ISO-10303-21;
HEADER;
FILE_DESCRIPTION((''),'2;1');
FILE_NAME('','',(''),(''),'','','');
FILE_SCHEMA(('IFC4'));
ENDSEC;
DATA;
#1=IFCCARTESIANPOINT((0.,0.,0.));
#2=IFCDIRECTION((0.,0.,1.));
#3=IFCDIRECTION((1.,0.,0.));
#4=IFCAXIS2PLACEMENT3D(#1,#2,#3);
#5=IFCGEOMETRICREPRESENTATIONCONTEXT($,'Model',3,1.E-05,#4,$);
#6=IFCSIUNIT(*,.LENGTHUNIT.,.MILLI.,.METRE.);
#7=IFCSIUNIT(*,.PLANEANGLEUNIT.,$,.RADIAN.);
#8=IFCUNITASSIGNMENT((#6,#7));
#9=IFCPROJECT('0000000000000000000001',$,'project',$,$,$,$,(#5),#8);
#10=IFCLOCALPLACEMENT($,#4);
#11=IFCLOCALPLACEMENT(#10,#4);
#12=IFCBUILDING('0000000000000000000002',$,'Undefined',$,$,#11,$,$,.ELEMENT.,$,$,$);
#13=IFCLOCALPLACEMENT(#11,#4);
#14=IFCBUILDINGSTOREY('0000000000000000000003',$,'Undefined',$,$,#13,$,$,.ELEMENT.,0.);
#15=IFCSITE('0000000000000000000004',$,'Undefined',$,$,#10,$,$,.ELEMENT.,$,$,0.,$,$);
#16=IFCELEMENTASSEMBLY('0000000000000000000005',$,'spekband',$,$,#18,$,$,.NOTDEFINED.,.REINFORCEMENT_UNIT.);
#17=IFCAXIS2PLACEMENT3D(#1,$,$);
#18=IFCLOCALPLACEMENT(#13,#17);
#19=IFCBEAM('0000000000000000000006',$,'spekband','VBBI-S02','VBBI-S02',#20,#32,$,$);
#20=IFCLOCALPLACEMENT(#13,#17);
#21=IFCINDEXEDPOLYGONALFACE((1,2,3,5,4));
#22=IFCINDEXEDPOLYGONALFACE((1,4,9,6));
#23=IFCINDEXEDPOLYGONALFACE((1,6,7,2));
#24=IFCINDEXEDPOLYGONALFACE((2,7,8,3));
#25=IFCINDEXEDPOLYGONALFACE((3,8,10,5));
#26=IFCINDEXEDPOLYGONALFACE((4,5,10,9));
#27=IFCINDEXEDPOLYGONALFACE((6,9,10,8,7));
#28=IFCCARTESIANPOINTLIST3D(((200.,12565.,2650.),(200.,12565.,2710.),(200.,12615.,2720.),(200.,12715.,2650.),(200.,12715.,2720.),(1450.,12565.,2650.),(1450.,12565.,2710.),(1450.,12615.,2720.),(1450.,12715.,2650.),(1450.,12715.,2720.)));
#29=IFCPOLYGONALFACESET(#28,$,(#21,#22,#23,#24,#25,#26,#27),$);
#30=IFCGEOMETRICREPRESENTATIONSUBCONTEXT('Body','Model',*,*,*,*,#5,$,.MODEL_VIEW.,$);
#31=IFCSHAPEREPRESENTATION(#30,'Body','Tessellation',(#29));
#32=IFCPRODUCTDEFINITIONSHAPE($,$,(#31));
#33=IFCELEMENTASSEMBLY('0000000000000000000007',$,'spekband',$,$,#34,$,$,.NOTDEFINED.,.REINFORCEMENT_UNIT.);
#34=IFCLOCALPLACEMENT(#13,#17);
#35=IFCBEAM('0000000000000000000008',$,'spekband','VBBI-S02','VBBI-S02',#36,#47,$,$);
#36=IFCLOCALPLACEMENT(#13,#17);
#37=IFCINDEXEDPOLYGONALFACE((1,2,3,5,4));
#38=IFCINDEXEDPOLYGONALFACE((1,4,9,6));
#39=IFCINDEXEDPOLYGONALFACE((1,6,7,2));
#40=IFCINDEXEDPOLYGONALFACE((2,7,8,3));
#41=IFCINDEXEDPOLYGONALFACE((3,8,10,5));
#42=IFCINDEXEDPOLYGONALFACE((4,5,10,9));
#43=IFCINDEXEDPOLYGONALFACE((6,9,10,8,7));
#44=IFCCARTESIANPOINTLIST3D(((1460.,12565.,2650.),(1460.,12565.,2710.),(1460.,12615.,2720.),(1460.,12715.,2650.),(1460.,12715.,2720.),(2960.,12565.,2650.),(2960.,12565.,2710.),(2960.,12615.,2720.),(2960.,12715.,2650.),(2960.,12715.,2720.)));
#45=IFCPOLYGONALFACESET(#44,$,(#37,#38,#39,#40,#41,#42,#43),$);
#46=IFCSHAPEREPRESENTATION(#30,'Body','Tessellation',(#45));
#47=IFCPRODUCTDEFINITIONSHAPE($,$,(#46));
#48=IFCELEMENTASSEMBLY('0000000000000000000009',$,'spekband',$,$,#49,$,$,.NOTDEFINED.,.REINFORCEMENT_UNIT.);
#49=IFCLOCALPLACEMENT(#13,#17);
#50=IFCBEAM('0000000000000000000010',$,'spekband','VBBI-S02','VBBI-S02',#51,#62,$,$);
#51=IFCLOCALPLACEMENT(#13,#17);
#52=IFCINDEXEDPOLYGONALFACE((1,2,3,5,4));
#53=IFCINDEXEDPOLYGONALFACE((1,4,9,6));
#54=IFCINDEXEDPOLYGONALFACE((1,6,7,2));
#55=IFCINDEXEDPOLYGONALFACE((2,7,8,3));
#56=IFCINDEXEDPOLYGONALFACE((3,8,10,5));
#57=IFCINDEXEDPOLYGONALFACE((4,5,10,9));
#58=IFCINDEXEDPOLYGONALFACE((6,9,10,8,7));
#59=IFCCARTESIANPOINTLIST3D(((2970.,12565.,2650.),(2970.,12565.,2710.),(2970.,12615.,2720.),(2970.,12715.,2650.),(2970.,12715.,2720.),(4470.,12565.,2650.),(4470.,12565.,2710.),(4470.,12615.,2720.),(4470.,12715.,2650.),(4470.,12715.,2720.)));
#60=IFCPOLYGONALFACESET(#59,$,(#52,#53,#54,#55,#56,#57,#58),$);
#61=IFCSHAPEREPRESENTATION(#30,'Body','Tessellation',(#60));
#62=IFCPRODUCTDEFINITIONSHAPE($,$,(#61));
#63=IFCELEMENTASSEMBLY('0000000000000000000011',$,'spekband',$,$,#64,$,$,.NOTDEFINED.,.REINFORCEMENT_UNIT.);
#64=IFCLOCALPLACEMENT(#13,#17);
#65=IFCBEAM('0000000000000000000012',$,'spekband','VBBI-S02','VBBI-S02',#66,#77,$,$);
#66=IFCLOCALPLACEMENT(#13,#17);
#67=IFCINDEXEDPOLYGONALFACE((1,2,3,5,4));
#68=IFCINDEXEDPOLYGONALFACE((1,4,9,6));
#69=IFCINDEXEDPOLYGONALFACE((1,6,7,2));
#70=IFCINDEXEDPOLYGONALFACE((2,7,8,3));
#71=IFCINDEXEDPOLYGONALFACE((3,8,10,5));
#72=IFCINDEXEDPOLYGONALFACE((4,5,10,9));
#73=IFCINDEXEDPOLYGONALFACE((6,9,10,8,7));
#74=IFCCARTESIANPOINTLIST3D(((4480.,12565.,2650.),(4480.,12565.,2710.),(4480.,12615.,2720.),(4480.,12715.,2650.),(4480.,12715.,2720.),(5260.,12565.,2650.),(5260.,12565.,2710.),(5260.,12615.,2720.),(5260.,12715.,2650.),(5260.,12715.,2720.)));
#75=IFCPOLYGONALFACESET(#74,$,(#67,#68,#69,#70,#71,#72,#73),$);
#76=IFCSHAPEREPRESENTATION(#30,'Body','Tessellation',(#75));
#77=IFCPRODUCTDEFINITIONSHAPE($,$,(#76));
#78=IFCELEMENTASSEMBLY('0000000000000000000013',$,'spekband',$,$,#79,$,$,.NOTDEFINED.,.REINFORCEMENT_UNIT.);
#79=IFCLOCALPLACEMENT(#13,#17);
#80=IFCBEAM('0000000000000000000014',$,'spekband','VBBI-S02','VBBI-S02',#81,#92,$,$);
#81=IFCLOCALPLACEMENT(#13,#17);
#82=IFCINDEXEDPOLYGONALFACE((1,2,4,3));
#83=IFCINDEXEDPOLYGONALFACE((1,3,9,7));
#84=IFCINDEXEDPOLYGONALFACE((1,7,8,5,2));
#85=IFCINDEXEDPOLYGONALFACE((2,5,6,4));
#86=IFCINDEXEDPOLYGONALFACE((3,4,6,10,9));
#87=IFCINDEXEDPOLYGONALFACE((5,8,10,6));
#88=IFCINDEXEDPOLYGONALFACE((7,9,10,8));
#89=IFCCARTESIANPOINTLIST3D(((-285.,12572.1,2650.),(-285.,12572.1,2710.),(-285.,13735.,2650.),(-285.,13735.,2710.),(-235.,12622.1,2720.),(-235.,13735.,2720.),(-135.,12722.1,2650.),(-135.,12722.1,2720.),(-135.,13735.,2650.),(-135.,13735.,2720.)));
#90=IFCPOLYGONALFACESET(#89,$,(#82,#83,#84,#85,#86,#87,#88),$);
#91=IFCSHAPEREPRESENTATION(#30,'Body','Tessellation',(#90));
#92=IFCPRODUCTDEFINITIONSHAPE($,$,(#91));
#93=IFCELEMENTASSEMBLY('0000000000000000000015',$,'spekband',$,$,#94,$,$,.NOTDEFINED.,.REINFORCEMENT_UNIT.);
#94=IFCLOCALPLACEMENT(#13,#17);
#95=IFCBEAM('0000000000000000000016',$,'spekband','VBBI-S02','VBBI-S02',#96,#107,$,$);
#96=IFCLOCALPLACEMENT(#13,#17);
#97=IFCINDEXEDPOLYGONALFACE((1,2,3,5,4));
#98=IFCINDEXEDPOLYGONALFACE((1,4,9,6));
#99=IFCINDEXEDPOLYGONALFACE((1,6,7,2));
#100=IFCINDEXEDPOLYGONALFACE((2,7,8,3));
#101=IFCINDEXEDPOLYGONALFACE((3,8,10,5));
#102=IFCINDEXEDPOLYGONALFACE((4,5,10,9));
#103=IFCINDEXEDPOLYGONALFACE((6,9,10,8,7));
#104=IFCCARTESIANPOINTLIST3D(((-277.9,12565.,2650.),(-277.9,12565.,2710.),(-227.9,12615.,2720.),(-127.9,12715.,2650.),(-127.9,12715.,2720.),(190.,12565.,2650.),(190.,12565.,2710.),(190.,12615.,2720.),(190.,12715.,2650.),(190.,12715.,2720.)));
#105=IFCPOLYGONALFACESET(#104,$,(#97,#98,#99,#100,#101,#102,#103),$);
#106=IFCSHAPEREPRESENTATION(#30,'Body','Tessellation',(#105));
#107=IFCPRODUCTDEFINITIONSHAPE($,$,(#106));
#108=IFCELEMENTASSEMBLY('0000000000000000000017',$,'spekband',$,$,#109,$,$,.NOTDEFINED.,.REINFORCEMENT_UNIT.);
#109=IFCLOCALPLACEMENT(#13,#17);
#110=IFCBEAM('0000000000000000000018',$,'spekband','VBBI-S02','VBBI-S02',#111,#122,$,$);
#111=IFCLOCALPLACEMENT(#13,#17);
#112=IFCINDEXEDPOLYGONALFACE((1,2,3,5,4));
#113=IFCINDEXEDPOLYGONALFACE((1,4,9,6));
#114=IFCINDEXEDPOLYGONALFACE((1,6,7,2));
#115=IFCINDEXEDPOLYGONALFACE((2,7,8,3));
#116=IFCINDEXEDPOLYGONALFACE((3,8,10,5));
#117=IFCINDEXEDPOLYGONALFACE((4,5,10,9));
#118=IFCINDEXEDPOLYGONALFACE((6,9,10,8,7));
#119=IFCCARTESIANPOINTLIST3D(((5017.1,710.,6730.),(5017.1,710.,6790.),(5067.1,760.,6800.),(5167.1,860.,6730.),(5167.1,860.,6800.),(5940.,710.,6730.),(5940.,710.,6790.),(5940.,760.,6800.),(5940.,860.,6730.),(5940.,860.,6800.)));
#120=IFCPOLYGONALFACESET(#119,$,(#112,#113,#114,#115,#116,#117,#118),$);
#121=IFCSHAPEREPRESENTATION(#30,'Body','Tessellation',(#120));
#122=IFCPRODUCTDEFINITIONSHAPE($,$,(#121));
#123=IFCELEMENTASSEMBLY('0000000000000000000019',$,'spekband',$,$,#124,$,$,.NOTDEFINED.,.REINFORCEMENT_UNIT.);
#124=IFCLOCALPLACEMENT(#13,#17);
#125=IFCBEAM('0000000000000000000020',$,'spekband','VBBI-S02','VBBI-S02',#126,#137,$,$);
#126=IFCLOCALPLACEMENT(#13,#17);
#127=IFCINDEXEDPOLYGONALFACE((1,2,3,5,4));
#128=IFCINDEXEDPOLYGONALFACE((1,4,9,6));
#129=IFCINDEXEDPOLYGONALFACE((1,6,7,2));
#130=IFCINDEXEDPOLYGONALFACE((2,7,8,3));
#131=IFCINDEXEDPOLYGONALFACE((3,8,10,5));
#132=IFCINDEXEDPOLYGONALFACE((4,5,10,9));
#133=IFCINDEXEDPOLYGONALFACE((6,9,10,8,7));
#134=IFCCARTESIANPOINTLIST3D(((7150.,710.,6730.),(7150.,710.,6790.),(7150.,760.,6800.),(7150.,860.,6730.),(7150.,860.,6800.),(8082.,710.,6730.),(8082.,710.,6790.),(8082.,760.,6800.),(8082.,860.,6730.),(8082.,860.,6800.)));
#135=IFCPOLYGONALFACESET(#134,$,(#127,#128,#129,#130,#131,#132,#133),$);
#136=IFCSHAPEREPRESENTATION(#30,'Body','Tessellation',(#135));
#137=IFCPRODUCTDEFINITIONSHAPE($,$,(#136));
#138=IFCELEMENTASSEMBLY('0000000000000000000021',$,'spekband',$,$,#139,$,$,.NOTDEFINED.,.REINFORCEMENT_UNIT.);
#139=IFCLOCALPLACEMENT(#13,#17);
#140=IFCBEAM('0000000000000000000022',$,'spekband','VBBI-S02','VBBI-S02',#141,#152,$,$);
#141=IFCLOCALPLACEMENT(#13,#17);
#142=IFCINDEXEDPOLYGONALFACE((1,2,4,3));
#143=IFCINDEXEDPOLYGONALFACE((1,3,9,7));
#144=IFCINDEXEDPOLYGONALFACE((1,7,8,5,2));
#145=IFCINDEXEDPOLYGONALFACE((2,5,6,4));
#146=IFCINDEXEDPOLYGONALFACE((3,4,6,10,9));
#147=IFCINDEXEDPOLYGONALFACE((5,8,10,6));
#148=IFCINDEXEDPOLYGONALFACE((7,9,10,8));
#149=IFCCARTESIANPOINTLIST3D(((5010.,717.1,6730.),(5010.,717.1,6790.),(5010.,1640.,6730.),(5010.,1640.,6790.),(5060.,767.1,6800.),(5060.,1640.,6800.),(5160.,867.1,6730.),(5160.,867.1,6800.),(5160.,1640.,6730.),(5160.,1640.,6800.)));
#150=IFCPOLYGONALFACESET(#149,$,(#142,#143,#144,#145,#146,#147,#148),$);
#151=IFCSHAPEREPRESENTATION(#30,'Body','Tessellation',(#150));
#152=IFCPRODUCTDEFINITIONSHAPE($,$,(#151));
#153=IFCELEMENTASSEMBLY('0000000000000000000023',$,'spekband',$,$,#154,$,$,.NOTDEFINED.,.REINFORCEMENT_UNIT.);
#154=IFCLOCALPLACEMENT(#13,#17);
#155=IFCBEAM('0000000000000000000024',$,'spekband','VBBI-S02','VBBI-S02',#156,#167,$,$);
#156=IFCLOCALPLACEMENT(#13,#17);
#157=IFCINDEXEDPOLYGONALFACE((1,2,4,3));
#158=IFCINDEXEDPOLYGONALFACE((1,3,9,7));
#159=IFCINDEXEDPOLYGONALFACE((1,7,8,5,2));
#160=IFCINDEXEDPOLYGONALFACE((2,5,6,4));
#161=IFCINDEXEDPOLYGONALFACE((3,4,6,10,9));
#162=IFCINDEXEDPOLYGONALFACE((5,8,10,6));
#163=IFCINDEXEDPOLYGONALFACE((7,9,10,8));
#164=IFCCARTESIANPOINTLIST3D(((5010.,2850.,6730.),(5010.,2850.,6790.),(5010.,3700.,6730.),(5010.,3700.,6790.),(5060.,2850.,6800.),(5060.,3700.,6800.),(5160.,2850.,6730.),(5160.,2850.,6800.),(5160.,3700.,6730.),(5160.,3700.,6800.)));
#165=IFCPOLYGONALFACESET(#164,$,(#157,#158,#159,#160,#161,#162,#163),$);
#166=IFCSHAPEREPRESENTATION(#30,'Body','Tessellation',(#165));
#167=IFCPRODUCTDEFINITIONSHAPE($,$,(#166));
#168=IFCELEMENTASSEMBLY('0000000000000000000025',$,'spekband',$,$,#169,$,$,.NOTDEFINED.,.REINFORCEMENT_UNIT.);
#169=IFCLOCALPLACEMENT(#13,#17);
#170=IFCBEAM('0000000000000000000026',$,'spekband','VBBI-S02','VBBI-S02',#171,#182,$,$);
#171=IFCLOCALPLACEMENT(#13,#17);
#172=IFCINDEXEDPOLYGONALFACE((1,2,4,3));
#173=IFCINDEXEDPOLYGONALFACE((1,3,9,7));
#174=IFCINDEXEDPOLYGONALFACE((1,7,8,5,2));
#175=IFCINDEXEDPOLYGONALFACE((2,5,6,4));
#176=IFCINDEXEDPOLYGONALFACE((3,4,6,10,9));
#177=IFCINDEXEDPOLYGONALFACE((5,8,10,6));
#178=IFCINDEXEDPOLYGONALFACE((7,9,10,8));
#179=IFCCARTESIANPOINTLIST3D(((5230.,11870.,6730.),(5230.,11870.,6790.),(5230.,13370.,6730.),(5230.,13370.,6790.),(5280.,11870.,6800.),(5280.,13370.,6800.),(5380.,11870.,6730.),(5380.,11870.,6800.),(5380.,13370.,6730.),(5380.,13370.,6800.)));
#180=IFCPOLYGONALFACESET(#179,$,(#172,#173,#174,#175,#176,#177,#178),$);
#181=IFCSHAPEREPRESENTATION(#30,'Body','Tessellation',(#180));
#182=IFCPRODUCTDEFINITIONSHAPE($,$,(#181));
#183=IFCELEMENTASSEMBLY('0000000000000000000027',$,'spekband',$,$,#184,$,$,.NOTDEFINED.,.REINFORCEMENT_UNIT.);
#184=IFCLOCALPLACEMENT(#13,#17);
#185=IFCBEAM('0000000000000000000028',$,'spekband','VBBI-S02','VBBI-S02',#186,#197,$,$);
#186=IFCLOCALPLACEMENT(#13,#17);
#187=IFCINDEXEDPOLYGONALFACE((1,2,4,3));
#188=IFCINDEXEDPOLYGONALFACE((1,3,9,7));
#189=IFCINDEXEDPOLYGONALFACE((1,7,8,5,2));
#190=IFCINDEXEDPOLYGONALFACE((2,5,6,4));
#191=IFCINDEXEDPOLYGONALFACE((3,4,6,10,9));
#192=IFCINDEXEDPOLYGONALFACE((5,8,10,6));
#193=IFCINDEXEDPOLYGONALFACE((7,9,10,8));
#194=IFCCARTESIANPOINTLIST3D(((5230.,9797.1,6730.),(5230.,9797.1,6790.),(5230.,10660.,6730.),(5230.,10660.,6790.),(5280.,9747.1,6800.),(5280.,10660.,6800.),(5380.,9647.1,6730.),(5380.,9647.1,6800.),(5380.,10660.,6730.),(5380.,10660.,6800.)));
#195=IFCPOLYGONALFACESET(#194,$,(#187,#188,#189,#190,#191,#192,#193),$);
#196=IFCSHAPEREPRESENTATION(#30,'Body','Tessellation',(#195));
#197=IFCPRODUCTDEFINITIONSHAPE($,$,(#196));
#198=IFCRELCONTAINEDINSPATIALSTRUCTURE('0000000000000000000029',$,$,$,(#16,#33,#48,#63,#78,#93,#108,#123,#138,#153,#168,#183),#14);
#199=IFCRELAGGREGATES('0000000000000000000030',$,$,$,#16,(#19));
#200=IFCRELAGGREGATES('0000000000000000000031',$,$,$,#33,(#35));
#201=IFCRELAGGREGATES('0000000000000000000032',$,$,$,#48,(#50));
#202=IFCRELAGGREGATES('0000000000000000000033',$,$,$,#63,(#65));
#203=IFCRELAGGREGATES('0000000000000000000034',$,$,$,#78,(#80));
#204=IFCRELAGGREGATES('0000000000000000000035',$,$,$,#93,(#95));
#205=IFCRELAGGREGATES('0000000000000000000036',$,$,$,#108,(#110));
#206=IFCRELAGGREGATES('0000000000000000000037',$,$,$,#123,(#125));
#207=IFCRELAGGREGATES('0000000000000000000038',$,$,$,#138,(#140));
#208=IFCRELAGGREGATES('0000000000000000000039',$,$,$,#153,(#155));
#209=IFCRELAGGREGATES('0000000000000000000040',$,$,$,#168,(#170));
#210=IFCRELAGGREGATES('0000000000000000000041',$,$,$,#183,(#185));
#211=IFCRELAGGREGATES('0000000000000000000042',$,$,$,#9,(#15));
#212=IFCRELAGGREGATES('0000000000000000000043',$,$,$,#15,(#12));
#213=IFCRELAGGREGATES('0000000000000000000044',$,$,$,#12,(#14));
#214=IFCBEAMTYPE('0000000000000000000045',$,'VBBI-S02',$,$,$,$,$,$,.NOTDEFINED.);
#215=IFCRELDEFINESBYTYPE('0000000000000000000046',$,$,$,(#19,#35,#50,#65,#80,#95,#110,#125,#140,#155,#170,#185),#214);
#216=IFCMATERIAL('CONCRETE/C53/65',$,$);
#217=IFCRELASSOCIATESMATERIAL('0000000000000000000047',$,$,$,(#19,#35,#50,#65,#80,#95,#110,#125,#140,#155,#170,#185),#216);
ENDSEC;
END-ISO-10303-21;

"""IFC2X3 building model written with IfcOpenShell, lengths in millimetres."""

from ifc_helpers import new_model, si_unit, frame, origin_with_axes, place, context, subcontext, project, spatial, polyline, outline, extrude, clip, halfspace, material, type_object, element, aggregate, save


model = new_model("IFC2X3")

# Units and contexts
model_context = context("Model", 3, precision=1e-05, world=origin_with_axes())
body_context = subcontext(model_context, "Body", "Model", "MODEL_VIEW")
ifc_project = project(units=[si_unit("LENGTHUNIT", "METRE", prefix="MILLI"), si_unit("PLANEANGLEUNIT", "RADIAN")], contexts=[model_context])

# Site, building, storey
site_placement = place(None, origin_with_axes())
site = spatial("IfcSite", under=ifc_project, at=site_placement, Name="Undefined", CompositionType="ELEMENT", RefElevation=0.0)
building_placement = place(site_placement, origin_with_axes())
building = spatial("IfcBuilding", under=site, at=building_placement, Name="Undefined", CompositionType="ELEMENT")
storey_placement = place(building_placement, origin_with_axes())
storey = spatial("IfcBuildingStorey", under=building, at=storey_placement, Name="Undefined", CompositionType="ELEMENT", Elevation=0.0)

# Element assemblies, beams
assembly_1_placement = place(storey_placement, origin_with_axes())
assembly_1 = element("IfcElementAssembly", 1, at=assembly_1_placement, inside=storey, Name="spekband", AssemblyPlace="NOTDEFINED", PredefinedType="REINFORCEMENT_UNIT")
ifc_material = material(Name="CONCRETE/C53/65")
beam_type_1 = type_object("IfcBeamType", Name="VBBI-S02", PredefinedType="NOTDEFINED")
beam_1_placement = place(assembly_1_placement, frame((200.0, 12640.0, 2685.0), z_axis=(0.0, -1.0, 0.0), x_axis=(1.0, 0.0, 0.0)))
beam_1 = element("IfcBeam", 2, at=beam_1_placement, type_object=beam_type_1, material=ifc_material, Name="spekband", Description="VBBI-S02", ObjectType="VBBI-S02", context=body_context, shape_type="SweptSolid", body=[
    extrude(outline(polyline([(35.0, -75.0), (-35.0, -75.0), (-35.0, 25.0), (-25.0, 75.0), (35.0, 75.0), (35.0, -75.0)])), frame((1250.0, 0.0, 0.0), z_axis=(-1.0, 0.0, 0.0), x_axis=(0.0, -1.0, 0.0)), (0.0, 0.0, 1.0), 1250.0),
])
aggregate(assembly_1, [beam_1])
assembly_2_placement = place(storey_placement, origin_with_axes())
assembly_2 = element("IfcElementAssembly", 3, at=assembly_2_placement, inside=storey, Name="spekband", AssemblyPlace="NOTDEFINED", PredefinedType="REINFORCEMENT_UNIT")
beam_2_placement = place(assembly_2_placement, frame((1460.0, 12640.0, 2685.0), z_axis=(0.0, -1.0, 0.0), x_axis=(1.0, 0.0, 0.0)))
beam_2 = element("IfcBeam", 4, at=beam_2_placement, type_object=beam_type_1, material=ifc_material, Name="spekband", Description="VBBI-S02", ObjectType="VBBI-S02", context=body_context, shape_type="SweptSolid", body=[
    extrude(outline(polyline([(35.0, -75.0), (-35.0, -75.0), (-35.0, 25.0), (-25.0, 75.0), (35.0, 75.0), (35.0, -75.0)])), frame((1500.0, 0.0, 0.0), z_axis=(-1.0, 0.0, 0.0), x_axis=(0.0, -1.0, 0.0)), (0.0, 0.0, 1.0), 1500.0),
])
aggregate(assembly_2, [beam_2])
assembly_3_placement = place(storey_placement, origin_with_axes())
assembly_3 = element("IfcElementAssembly", 5, at=assembly_3_placement, inside=storey, Name="spekband", AssemblyPlace="NOTDEFINED", PredefinedType="REINFORCEMENT_UNIT")
beam_3_placement = place(assembly_3_placement, frame((2970.0, 12640.0, 2685.0), z_axis=(0.0, -1.0, 0.0), x_axis=(1.0, 0.0, 0.0)))
beam_3 = element("IfcBeam", 6, at=beam_3_placement, type_object=beam_type_1, material=ifc_material, Name="spekband", Description="VBBI-S02", ObjectType="VBBI-S02", context=body_context, shape_type="SweptSolid", body=[
    extrude(outline(polyline([(35.0, -75.0), (-35.0, -75.0), (-35.0, 25.0), (-25.0, 75.0), (35.0, 75.0), (35.0, -75.0)])), frame((1500.0, 0.0, 0.0), z_axis=(-1.0, 0.0, 0.0), x_axis=(0.0, -1.0, 0.0)), (0.0, 0.0, 1.0), 1500.0),
])
aggregate(assembly_3, [beam_3])
assembly_4_placement = place(storey_placement, origin_with_axes())
assembly_4 = element("IfcElementAssembly", 7, at=assembly_4_placement, inside=storey, Name="spekband", AssemblyPlace="NOTDEFINED", PredefinedType="REINFORCEMENT_UNIT")
beam_4_placement = place(assembly_4_placement, frame((4480.0, 12640.0, 2685.0), z_axis=(0.0, -1.0, 0.0), x_axis=(1.0, 0.0, 0.0)))
beam_4 = element("IfcBeam", 8, at=beam_4_placement, type_object=beam_type_1, material=ifc_material, Name="spekband", Description="VBBI-S02", ObjectType="VBBI-S02", context=body_context, shape_type="SweptSolid", body=[
    extrude(outline(polyline([(35.0, -75.0), (-35.0, -75.0), (-35.0, 25.0), (-25.0, 75.0), (35.0, 75.0), (35.0, -75.0)])), frame((780.0, 0.0, 0.0), z_axis=(-1.0, 0.0, 0.0), x_axis=(0.0, -1.0, 0.0)), (0.0, 0.0, 1.0), 780.0),
])
aggregate(assembly_4, [beam_4])
assembly_5_placement = place(storey_placement, origin_with_axes())
assembly_5 = element("IfcElementAssembly", 9, at=assembly_5_placement, inside=storey, Name="spekband", AssemblyPlace="NOTDEFINED", PredefinedType="REINFORCEMENT_UNIT")
beam_5_placement = place(assembly_5_placement, frame((-210.0, 13735.0, 2685.0), z_axis=(-1.0, 0.0, 0.0), x_axis=(0.0, -1.0, 0.0)))
beam_5 = element("IfcBeam", 10, at=beam_5_placement, type_object=beam_type_1, material=ifc_material, Name="spekband", Description="VBBI-S02", ObjectType="VBBI-S02", context=body_context, shape_type="Clipping", body=[
    clip(extrude(outline(polyline([(35.0, -75.0), (-35.0, -75.0), (-35.0, 25.0), (-25.0, 75.0), (35.0, 75.0), (35.0, -75.0)])), frame((1163.7, 0.0, 0.0), z_axis=(-1.0, 0.0, 0.0), x_axis=(0.0, -1.0, 0.0)), (0.0, 0.0, 1.0), 1163.7), halfspace(frame((1166.5, 0.0, 78.5), z_axis=(0.707107, 0.0, -0.707107), x_axis=(0.0, 1.0, 0.0)), False)),
])
aggregate(assembly_5, [beam_5])
assembly_6_placement = place(storey_placement, origin_with_axes())
assembly_6 = element("IfcElementAssembly", 11, at=assembly_6_placement, inside=storey, Name="spekband", AssemblyPlace="NOTDEFINED", PredefinedType="REINFORCEMENT_UNIT")
beam_6_placement = place(assembly_6_placement, frame((-285.0, 12640.0, 2685.0), z_axis=(0.0, -1.0, 0.0), x_axis=(1.0, 0.0, 0.0)))
beam_6 = element("IfcBeam", 12, at=beam_6_placement, type_object=beam_type_1, material=ifc_material, Name="spekband", Description="VBBI-S02", ObjectType="VBBI-S02", context=body_context, shape_type="Clipping", body=[
    clip(extrude(outline(polyline([(35.0, -75.0), (-35.0, -75.0), (-35.0, 25.0), (-25.0, 75.0), (35.0, 75.0), (35.0, -75.0)])), frame((475.0, 0.0, 0.0), z_axis=(-1.0, 0.0, 0.0), x_axis=(0.0, -1.0, 0.0)), (0.0, 0.0, 1.0), 468.7), halfspace(frame((3.5, 0.0, 78.5), z_axis=(0.707107, 0.0, 0.707107), x_axis=(0.0, 1.0, 0.0)), True)),
])
aggregate(assembly_6, [beam_6])
assembly_7_placement = place(storey_placement, origin_with_axes())
assembly_7 = element("IfcElementAssembly", 13, at=assembly_7_placement, inside=storey, Name="spekband", AssemblyPlace="NOTDEFINED", PredefinedType="REINFORCEMENT_UNIT")
beam_7_placement = place(assembly_7_placement, frame((5010.0, 785.0, 6765.0), z_axis=(0.0, -1.0, 0.0), x_axis=(1.0, 0.0, 0.0)))
beam_7 = element("IfcBeam", 14, at=beam_7_placement, type_object=beam_type_1, material=ifc_material, Name="spekband", Description="VBBI-S02", ObjectType="VBBI-S02", context=body_context, shape_type="Clipping", body=[
    clip(extrude(outline(polyline([(35.0, -75.0), (-35.0, -75.0), (-35.0, 25.0), (-25.0, 75.0), (35.0, 75.0), (35.0, -75.0)])), frame((930.0, 0.0, 0.0), z_axis=(-1.0, 0.0, 0.0), x_axis=(0.0, -1.0, 0.0)), (0.0, 0.0, 1.0), 923.7), halfspace(frame((3.5, 0.0, 78.5), z_axis=(0.707107, 0.0, 0.707107), x_axis=(0.0, 1.0, 0.0)), True)),
])
aggregate(assembly_7, [beam_7])
assembly_8_placement = place(storey_placement, origin_with_axes())
assembly_8 = element("IfcElementAssembly", 15, at=assembly_8_placement, inside=storey, Name="spekband", AssemblyPlace="NOTDEFINED", PredefinedType="REINFORCEMENT_UNIT")
beam_8_placement = place(assembly_8_placement, frame((7150.0, 785.0, 6765.0), z_axis=(0.0, -1.0, 0.0), x_axis=(1.0, 0.0, 0.0)))
beam_8 = element("IfcBeam", 16, at=beam_8_placement, type_object=beam_type_1, material=ifc_material, Name="spekband", Description="VBBI-S02", ObjectType="VBBI-S02", context=body_context, shape_type="SweptSolid", body=[
    extrude(outline(polyline([(35.0, -75.0), (-35.0, -75.0), (-35.0, 25.0), (-25.0, 75.0), (35.0, 75.0), (35.0, -75.0)])), frame((932.0, 0.0, 0.0), z_axis=(-1.0, 0.0, 0.0), x_axis=(0.0, -1.0, 0.0)), (0.0, 0.0, 1.0), 932.0),
])
aggregate(assembly_8, [beam_8])
assembly_9_placement = place(storey_placement, origin_with_axes())
assembly_9 = element("IfcElementAssembly", 17, at=assembly_9_placement, inside=storey, Name="spekband", AssemblyPlace="NOTDEFINED", PredefinedType="REINFORCEMENT_UNIT")
beam_9_placement = place(assembly_9_placement, frame((5085.0, 1640.0, 6765.0), z_axis=(-1.0, 0.0, 0.0), x_axis=(0.0, -1.0, 0.0)))
beam_9 = element("IfcBeam", 18, at=beam_9_placement, type_object=beam_type_1, material=ifc_material, Name="spekband", Description="VBBI-S02", ObjectType="VBBI-S02", context=body_context, shape_type="Clipping", body=[
    clip(extrude(outline(polyline([(35.0, -75.0), (-35.0, -75.0), (-35.0, 25.0), (-25.0, 75.0), (35.0, 75.0), (35.0, -75.0)])), frame((923.7, 0.0, 0.0), z_axis=(-1.0, 0.0, 0.0), x_axis=(0.0, -1.0, 0.0)), (0.0, 0.0, 1.0), 923.7), halfspace(frame((926.5, 0.0, 78.5), z_axis=(0.707107, 0.0, -0.707107), x_axis=(0.0, 1.0, 0.0)), False)),
])
aggregate(assembly_9, [beam_9])
assembly_10_placement = place(storey_placement, origin_with_axes())
assembly_10 = element("IfcElementAssembly", 19, at=assembly_10_placement, inside=storey, Name="spekband", AssemblyPlace="NOTDEFINED", PredefinedType="REINFORCEMENT_UNIT")
beam_10_placement = place(assembly_10_placement, frame((5085.0, 3700.0, 6765.0), z_axis=(-1.0, 0.0, 0.0), x_axis=(0.0, -1.0, 0.0)))
beam_10 = element("IfcBeam", 20, at=beam_10_placement, type_object=beam_type_1, material=ifc_material, Name="spekband", Description="VBBI-S02", ObjectType="VBBI-S02", context=body_context, shape_type="SweptSolid", body=[
    extrude(outline(polyline([(35.0, -75.0), (-35.0, -75.0), (-35.0, 25.0), (-25.0, 75.0), (35.0, 75.0), (35.0, -75.0)])), frame((850.0, 0.0, 0.0), z_axis=(-1.0, 0.0, 0.0), x_axis=(0.0, -1.0, 0.0)), (0.0, 0.0, 1.0), 850.0),
])
aggregate(assembly_10, [beam_10])
assembly_11_placement = place(storey_placement, origin_with_axes())
assembly_11 = element("IfcElementAssembly", 21, at=assembly_11_placement, inside=storey, Name="spekband", AssemblyPlace="NOTDEFINED", PredefinedType="REINFORCEMENT_UNIT")
beam_11_placement = place(assembly_11_placement, frame((5305.0, 13370.0, 6765.0), z_axis=(-1.0, 0.0, 0.0), x_axis=(0.0, -1.0, 0.0)))
beam_11 = element("IfcBeam", 22, at=beam_11_placement, type_object=beam_type_1, material=ifc_material, Name="spekband", Description="VBBI-S02", ObjectType="VBBI-S02", context=body_context, shape_type="SweptSolid", body=[
    extrude(outline(polyline([(35.0, -75.0), (-35.0, -75.0), (-35.0, 25.0), (-25.0, 75.0), (35.0, 75.0), (35.0, -75.0)])), frame((1500.0, 0.0, 0.0), z_axis=(-1.0, 0.0, 0.0), x_axis=(0.0, -1.0, 0.0)), (0.0, 0.0, 1.0), 1500.0),
])
aggregate(assembly_11, [beam_11])
assembly_12_placement = place(storey_placement, origin_with_axes())
assembly_12 = element("IfcElementAssembly", 23, at=assembly_12_placement, inside=storey, Name="spekband", AssemblyPlace="NOTDEFINED", PredefinedType="REINFORCEMENT_UNIT")
beam_12_placement = place(assembly_12_placement, frame((5305.0, 10660.0, 6765.0), z_axis=(-1.0, 0.0, 0.0), x_axis=(0.0, -1.0, 0.0)))
beam_12 = element("IfcBeam", 24, at=beam_12_placement, type_object=beam_type_1, material=ifc_material, Name="spekband", Description="VBBI-S02", ObjectType="VBBI-S02", context=body_context, shape_type="Clipping", body=[
    clip(extrude(outline(polyline([(35.0, -75.0), (-35.0, -75.0), (-35.0, 25.0), (-25.0, 75.0), (35.0, 75.0), (35.0, -75.0)])), frame((1013.7, 0.0, 0.0), z_axis=(-1.0, 0.0, 0.0), x_axis=(0.0, -1.0, 0.0)), (0.0, 0.0, 1.0), 1013.7), halfspace(frame((1016.5, 0.0, -78.5), z_axis=(-0.707107, 0.0, -0.707107), x_axis=(0.0, 1.0, 0.0)), True)),
])
aggregate(assembly_12, [beam_12])

save(model, "model.ifc")
